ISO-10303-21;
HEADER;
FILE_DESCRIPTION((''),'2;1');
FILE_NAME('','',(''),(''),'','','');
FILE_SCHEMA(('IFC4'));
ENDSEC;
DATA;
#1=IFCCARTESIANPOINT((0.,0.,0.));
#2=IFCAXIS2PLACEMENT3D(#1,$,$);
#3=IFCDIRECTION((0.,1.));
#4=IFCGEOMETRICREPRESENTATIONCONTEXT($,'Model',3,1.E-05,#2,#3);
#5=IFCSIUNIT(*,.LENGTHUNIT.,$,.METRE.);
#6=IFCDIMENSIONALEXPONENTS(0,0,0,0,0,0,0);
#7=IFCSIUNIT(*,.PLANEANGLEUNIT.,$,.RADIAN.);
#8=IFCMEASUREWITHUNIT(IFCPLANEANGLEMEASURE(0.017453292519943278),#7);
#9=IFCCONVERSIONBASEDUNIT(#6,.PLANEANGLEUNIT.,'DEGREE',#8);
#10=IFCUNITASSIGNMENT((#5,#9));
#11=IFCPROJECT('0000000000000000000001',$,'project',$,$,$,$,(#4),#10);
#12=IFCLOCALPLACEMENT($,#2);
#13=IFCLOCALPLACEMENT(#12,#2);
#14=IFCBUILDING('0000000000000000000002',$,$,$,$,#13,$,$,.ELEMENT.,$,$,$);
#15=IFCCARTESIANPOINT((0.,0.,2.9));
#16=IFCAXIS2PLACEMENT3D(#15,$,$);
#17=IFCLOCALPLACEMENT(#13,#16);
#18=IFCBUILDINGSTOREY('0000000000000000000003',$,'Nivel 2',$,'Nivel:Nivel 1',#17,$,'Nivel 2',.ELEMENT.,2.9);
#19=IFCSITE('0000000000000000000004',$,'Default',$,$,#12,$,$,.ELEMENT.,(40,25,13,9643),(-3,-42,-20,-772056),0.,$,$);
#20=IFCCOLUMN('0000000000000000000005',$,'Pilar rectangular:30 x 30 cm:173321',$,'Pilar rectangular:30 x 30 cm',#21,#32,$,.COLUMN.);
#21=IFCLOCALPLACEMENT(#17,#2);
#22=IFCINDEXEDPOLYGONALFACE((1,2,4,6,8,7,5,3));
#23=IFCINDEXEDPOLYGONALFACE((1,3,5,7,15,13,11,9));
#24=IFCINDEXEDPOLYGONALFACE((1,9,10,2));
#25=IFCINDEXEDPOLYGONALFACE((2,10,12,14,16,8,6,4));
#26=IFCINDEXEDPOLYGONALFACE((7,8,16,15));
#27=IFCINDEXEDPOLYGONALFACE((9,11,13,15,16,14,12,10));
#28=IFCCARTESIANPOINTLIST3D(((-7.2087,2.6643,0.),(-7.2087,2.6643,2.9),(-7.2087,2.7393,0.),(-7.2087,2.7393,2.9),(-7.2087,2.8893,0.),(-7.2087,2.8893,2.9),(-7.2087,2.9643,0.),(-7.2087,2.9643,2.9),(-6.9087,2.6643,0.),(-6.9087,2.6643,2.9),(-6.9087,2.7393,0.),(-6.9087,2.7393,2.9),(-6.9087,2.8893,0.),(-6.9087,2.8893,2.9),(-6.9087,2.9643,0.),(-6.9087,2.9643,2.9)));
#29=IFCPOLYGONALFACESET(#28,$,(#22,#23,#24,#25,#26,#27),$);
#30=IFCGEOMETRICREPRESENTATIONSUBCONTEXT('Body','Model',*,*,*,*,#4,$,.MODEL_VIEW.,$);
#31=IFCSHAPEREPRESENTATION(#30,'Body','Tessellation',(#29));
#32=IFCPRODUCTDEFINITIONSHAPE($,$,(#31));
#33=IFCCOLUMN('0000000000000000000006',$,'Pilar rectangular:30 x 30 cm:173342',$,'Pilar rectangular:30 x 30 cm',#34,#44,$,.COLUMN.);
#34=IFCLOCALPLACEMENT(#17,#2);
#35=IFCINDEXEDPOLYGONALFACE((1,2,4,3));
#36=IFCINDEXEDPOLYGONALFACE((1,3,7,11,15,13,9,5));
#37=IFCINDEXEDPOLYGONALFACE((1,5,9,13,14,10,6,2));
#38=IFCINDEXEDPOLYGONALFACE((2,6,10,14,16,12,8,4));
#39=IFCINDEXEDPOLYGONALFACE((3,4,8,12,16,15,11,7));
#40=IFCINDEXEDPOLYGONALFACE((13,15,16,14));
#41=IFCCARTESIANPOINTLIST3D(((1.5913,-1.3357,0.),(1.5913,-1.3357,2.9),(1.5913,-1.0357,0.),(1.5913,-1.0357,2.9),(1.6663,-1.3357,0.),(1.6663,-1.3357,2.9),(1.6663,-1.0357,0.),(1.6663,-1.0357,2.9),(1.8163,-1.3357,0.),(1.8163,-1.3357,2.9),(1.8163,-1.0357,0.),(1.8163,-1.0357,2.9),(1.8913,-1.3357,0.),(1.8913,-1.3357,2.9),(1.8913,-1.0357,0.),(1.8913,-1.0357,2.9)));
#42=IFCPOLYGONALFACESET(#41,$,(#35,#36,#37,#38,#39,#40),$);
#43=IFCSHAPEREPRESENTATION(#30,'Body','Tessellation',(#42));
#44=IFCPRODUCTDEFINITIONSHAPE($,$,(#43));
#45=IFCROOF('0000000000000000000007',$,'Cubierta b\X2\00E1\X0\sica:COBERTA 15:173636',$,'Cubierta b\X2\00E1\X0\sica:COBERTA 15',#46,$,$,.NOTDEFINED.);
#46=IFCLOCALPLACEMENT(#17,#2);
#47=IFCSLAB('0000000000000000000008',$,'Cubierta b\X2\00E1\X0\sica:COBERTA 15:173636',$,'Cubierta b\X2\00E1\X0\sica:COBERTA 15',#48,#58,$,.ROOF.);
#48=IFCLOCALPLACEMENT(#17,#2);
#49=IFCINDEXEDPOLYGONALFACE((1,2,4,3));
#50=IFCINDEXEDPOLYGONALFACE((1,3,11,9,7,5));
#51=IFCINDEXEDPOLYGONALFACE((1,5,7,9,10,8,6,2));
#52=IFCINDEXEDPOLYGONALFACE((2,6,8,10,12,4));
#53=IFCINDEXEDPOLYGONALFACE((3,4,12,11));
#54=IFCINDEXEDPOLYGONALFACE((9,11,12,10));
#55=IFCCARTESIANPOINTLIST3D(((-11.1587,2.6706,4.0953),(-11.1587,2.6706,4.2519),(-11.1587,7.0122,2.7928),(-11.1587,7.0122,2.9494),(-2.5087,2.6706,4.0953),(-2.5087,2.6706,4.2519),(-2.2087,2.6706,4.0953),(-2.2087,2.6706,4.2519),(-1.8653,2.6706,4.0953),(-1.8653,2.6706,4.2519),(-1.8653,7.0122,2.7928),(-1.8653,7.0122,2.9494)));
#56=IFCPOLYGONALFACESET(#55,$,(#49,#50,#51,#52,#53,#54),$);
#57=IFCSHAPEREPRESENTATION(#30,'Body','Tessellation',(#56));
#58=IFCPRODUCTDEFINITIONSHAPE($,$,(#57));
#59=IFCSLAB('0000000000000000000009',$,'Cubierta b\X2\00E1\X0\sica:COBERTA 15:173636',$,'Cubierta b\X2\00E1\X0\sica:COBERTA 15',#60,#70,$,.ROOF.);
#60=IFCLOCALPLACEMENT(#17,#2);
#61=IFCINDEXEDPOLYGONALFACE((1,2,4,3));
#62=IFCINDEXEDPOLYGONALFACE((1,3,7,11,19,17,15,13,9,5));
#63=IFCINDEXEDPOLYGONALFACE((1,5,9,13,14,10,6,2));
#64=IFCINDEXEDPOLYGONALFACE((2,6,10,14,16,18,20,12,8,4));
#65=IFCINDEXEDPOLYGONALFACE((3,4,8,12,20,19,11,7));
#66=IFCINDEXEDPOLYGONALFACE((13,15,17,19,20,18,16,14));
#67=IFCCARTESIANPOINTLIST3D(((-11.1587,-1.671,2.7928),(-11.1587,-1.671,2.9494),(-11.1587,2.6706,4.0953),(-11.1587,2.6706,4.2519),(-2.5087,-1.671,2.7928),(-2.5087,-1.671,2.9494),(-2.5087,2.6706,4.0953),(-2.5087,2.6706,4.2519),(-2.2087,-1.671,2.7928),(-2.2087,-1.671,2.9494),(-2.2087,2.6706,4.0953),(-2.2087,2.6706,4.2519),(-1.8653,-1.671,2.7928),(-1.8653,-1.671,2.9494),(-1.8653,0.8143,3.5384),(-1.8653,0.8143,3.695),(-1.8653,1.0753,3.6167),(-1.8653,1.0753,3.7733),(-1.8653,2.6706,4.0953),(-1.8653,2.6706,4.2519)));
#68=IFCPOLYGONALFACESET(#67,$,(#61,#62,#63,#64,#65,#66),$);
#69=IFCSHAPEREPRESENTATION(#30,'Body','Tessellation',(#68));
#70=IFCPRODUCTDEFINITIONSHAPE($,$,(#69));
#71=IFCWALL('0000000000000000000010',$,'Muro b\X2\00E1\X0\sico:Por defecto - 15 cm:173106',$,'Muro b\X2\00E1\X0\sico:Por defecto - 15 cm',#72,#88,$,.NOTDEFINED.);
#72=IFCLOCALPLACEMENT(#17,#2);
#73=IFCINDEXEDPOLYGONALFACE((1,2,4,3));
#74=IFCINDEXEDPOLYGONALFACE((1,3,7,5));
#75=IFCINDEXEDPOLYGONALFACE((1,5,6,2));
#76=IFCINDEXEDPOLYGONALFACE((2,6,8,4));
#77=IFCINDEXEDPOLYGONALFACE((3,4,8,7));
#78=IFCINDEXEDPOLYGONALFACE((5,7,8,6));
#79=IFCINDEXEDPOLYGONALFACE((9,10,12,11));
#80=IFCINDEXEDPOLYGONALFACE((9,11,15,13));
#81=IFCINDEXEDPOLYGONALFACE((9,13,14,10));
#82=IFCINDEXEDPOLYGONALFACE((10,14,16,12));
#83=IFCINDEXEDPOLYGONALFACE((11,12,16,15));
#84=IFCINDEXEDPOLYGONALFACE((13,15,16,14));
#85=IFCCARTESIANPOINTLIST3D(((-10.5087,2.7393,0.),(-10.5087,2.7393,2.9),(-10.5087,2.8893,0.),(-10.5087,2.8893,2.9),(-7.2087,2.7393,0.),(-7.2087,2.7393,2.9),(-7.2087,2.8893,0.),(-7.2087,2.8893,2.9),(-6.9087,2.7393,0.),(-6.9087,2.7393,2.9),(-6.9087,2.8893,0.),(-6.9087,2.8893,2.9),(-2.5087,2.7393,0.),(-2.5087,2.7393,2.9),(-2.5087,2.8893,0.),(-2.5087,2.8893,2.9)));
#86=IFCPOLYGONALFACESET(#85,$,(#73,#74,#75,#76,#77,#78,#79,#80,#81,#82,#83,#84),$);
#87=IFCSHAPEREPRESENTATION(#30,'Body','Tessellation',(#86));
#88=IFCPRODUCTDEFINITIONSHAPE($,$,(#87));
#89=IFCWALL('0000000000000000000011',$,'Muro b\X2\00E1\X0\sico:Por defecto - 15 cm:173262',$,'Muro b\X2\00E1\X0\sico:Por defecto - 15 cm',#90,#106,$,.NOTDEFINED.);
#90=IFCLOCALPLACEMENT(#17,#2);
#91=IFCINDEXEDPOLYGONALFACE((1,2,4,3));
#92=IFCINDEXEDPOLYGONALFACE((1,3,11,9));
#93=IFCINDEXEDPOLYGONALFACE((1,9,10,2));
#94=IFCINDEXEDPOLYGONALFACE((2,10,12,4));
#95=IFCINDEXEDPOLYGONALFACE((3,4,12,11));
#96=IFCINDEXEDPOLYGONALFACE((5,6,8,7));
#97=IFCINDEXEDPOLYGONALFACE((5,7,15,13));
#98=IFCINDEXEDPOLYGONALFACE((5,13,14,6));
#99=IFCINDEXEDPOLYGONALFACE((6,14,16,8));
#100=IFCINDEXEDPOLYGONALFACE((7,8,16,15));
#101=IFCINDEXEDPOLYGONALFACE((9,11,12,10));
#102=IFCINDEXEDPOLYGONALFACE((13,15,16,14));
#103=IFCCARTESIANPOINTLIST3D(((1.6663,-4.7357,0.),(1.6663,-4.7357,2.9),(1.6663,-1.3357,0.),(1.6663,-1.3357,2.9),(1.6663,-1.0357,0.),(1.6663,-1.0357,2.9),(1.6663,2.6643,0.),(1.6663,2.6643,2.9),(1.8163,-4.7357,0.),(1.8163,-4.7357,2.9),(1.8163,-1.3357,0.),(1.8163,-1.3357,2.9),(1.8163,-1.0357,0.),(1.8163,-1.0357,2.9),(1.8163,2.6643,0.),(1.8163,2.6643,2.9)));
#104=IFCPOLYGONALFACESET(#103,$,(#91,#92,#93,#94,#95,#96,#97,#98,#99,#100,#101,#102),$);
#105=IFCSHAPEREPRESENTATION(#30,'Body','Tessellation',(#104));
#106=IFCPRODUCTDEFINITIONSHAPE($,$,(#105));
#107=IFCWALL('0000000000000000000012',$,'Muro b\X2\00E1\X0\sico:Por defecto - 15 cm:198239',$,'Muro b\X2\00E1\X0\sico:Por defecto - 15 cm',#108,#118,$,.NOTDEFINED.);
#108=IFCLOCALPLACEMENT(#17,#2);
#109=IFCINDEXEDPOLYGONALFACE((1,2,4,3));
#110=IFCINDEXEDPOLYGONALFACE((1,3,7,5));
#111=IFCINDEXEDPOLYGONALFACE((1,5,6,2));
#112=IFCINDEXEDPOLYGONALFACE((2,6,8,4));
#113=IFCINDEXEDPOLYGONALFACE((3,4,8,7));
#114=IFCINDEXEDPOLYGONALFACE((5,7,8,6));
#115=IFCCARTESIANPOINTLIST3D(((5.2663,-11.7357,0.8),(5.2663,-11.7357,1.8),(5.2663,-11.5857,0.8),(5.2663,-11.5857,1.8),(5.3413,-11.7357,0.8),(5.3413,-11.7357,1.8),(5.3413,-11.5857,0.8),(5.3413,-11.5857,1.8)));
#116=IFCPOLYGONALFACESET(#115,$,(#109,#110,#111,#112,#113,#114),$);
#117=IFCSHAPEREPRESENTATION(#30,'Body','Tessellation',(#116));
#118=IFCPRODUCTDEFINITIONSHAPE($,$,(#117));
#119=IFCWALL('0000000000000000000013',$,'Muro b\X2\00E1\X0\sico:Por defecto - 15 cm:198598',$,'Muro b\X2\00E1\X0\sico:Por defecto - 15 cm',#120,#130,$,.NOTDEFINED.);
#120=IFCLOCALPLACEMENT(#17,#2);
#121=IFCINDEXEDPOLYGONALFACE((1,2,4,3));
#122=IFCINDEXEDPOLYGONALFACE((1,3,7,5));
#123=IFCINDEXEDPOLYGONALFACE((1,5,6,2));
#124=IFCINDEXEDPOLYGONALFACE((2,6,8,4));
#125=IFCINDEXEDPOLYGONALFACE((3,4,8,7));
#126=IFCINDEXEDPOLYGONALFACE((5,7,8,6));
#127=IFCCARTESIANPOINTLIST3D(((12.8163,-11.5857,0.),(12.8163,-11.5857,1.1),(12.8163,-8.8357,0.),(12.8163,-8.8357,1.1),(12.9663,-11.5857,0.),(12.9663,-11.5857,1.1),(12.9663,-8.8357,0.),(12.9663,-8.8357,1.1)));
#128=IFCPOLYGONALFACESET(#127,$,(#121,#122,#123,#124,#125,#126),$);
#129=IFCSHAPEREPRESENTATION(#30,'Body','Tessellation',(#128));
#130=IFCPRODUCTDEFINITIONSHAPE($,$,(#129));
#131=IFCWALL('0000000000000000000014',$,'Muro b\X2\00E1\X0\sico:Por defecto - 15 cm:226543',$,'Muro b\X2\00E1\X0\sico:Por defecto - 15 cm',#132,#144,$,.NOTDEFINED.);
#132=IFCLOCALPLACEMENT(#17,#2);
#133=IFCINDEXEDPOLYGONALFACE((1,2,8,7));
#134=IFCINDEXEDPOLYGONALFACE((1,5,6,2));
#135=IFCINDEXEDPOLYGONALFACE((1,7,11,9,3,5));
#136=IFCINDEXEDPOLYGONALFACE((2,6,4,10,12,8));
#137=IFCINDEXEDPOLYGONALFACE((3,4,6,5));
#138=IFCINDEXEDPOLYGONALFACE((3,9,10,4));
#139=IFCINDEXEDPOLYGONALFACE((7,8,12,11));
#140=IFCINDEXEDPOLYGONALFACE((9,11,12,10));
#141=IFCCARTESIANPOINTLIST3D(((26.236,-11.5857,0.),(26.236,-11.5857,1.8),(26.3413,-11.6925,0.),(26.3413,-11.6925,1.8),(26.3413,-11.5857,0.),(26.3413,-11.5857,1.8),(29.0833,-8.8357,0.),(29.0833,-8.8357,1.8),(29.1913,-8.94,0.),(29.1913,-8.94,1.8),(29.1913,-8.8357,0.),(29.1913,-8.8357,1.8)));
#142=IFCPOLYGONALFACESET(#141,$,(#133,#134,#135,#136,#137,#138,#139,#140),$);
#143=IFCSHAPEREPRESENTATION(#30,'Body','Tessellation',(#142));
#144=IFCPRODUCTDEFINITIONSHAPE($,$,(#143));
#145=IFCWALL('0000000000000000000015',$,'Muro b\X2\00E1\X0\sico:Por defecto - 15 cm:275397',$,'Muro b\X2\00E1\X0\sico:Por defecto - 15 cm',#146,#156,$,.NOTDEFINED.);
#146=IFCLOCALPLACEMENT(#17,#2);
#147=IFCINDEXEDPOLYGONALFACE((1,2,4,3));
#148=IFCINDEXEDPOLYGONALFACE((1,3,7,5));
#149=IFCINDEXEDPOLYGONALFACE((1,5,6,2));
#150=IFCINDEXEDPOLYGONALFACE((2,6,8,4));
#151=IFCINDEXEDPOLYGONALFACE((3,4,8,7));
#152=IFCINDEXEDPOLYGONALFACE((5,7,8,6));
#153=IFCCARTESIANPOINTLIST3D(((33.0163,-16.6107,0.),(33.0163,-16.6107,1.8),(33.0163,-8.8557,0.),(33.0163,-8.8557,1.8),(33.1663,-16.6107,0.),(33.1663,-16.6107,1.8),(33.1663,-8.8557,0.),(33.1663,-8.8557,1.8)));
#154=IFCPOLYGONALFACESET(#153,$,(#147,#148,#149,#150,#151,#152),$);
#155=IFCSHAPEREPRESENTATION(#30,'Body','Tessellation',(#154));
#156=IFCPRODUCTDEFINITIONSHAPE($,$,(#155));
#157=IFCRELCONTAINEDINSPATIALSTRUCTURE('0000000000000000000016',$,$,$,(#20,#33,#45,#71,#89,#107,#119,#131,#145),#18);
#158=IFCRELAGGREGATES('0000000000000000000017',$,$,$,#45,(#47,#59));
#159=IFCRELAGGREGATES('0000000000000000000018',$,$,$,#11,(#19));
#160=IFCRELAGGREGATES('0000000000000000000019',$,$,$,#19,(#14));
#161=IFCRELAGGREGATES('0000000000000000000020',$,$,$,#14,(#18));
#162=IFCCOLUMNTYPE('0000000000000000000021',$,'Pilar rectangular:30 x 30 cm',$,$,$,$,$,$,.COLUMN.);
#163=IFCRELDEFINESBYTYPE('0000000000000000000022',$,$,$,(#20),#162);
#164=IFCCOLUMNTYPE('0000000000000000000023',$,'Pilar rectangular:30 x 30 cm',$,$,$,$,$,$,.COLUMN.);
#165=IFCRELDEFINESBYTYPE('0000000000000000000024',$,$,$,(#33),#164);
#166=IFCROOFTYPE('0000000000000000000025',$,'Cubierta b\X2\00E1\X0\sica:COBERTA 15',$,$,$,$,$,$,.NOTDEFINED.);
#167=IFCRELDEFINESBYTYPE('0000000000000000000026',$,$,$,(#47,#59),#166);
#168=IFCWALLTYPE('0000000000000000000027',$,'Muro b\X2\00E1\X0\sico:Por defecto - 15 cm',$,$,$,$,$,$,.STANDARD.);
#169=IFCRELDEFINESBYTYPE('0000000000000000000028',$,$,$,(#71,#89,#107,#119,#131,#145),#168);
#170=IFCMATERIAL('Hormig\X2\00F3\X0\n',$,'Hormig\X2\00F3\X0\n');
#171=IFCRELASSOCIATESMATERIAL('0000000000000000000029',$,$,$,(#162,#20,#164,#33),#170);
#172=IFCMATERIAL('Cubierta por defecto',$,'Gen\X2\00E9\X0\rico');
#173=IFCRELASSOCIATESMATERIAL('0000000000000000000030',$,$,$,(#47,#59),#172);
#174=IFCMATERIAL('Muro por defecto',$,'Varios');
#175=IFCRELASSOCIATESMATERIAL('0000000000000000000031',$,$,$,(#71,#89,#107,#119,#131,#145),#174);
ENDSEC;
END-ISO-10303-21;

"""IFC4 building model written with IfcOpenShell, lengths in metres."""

from ifc_helpers import new_model, entity, si_unit, converted_unit, direction, frame, origin, place, context, subcontext, project, spatial, indexed_curve, outline, extrude, source, transform, mapped, material, type_object, type_shapes, element, aggregate, save


model = new_model("IFC4")

# Units and contexts
model_context = context("Model", 3, precision=1e-05, world=origin(), true_north=direction((0.0, 1.0)))
body_context = subcontext(model_context, "Body", "Model", "MODEL_VIEW")
ifc_project = project(units=[si_unit("LENGTHUNIT", "METRE"), converted_unit("PLANEANGLEUNIT", "DEGREE", entity("IfcPlaneAngleMeasure", 0.017453292519943278), si_unit("PLANEANGLEUNIT", "RADIAN"), dimensions=[0, 0, 0, 0, 0, 0, 0])], contexts=[model_context])

# Site, building, storey
site_placement = place(None, origin())
site = spatial("IfcSite", under=ifc_project, at=site_placement, Name="Default", CompositionType="ELEMENT", RefLatitude=(40, 25, 13, 9643), RefLongitude=(-3, -42, -20, -772056), RefElevation=0.0)
building_placement = place(site_placement, origin())
building = spatial("IfcBuilding", under=site, at=building_placement, CompositionType="ELEMENT")
storey_placement = place(building_placement, frame((0.0, 0.0, 2.9)))
storey = spatial("IfcBuildingStorey", under=building, at=storey_placement, Name="Nivel 2", ObjectType="Nivel:Nivel 1", LongName="Nivel 2", CompositionType="ELEMENT", Elevation=2.9)

# Columns
ifc_material_1 = material(Name="Hormigón", Category="Hormigón")
column_type_1 = type_object("IfcColumnType", Name="Pilar rectangular:30 x 30 cm", PredefinedType="COLUMN", material=ifc_material_1)
shared_shape_1 = source(origin(), body_context, "Body", "SweptSolid", [
    extrude(outline(indexed_curve([(-0.15, -0.15), (0.15, -0.15), (0.15, -0.075), (0.15, 0.075), (0.15, 0.15), (-0.15, 0.15), (-0.15, 0.075), (-0.15, -0.075), (-0.15, -0.15)], self_intersect=False)), frame((-7.0587, 2.8143, 2.9), z_axis=(0.0, 0.0, 1.0), x_axis=(-1.0, 0.0, 0.0)), (0.0, 0.0, 1.0), 2.9),
])
type_shapes(column_type_1, [shared_shape_1])
column_1_placement = place(storey_placement, frame((0.0, 0.0, -2.9)))
element("IfcColumn", 1, at=column_1_placement, inside=storey, type_object=column_type_1, material=ifc_material_1, Name="Pilar rectangular:30 x 30 cm:173321", ObjectType="Pilar rectangular:30 x 30 cm", PredefinedType="COLUMN", context=body_context, shape_type="MappedRepresentation", body=[
    mapped(shared_shape_1, transform((0.0, 0.0, 0.0), scale=1.0)),
])
column_type_2 = type_object("IfcColumnType", Name="Pilar rectangular:30 x 30 cm", PredefinedType="COLUMN", material=ifc_material_1)
shared_shape_2 = source(origin(), body_context, "Body", "SweptSolid", [
    extrude(outline(indexed_curve([(-0.15, -0.15), (-0.075, -0.15), (0.075, -0.15), (0.15, -0.15), (0.15, 0.15), (0.075, 0.15), (-0.075, 0.15), (-0.15, 0.15), (-0.15, -0.15)], self_intersect=False)), frame((1.7413, -1.1857, 2.9), z_axis=(0.0, 0.0, 1.0), x_axis=(-1.0, 0.0, 0.0)), (0.0, 0.0, 1.0), 2.9),
])
type_shapes(column_type_2, [shared_shape_2])
column_2_placement = place(storey_placement, frame((0.0, 0.0, -2.9)))
element("IfcColumn", 2, at=column_2_placement, inside=storey, type_object=column_type_2, material=ifc_material_1, Name="Pilar rectangular:30 x 30 cm:173342", ObjectType="Pilar rectangular:30 x 30 cm", PredefinedType="COLUMN", context=body_context, shape_type="MappedRepresentation", body=[
    mapped(shared_shape_2, transform((0.0, 0.0, 0.0), scale=1.0)),
])

# Roof, slabs
roof_placement = place(storey_placement, frame((-11.1587, -1.671, 2.7928)))
roof = element("IfcRoof", 3, at=roof_placement, inside=storey, Name="Cubierta básica:COBERTA 15:173636", ObjectType="Cubierta básica:COBERTA 15", PredefinedType="NOTDEFINED")
ifc_material_2 = material(Name="Cubierta por defecto", Category="Genérico")
roof_type = type_object("IfcRoofType", Name="Cubierta básica:COBERTA 15", PredefinedType="NOTDEFINED")
slab_1_placement = place(roof_placement, origin())
slab_1 = element("IfcSlab", 4, at=slab_1_placement, type_object=roof_type, material=ifc_material_2, Name="Cubierta básica:COBERTA 15:173636", ObjectType="Cubierta básica:COBERTA 15", PredefinedType="ROOF", context=body_context, shape_type="SweptSolid", body=[
    extrude(outline(indexed_curve([(4.6467, 2.2664), (-4.6467, 2.2664), (-4.6467, -2.2664), (4.0033, -2.2664), (4.3033, -2.2664), (4.6467, -2.2664), (4.6467, 2.2664)], self_intersect=False)), frame((4.6467, 6.5123, 0.6512), z_axis=(0.0, 0.287348, 0.957826), x_axis=(1.0, 0.0, 0.0)), (0.0, -0.287348, 0.957826), 0.1566),
])
slab_2_placement = place(roof_placement, origin())
slab_2 = element("IfcSlab", 5, at=slab_2_placement, type_object=roof_type, material=ifc_material_2, Name="Cubierta básica:COBERTA 15:173636", ObjectType="Cubierta básica:COBERTA 15", PredefinedType="ROOF", context=body_context, shape_type="SweptSolid", body=[
    extrude(outline(indexed_curve([(4.6467, 2.2664), (4.3033, 2.2664), (4.0033, 2.2664), (-4.6467, 2.2664), (-4.6467, -2.2664), (4.0033, -2.2664), (4.3033, -2.2664), (4.6467, -2.2664), (4.6467, 0.3283), (4.6467, 0.6008), (4.6467, 2.2664)], self_intersect=False)), frame((4.6467, 2.1708, 0.6512), z_axis=(0.0, -0.287348, 0.957826), x_axis=(1.0, 0.0, 0.0)), (0.0, 0.287348, 0.957826), 0.1566),
])
aggregate(roof, [slab_1, slab_2])

# Walls, openings
ifc_material_3 = material(Name="Muro por defecto", Category="Varios")
wall_type_1 = type_object("IfcWallType", Name="Muro básico:Por defecto - 15 cm", PredefinedType="STANDARD")
wall_1_placement = place(storey_placement, frame((-10.5087, 2.8143, 0.0)))
wall_1 = element("IfcWall", 6, at=wall_1_placement, inside=storey, type_object=wall_type_1, material=ifc_material_3, Name="Muro básico:Por defecto - 15 cm:173106", ObjectType="Muro básico:Por defecto - 15 cm", PredefinedType="NOTDEFINED", context=body_context, shape_type="SweptSolid", body=[
    extrude(outline(indexed_curve([(8.0, 0.075), (0.0, 0.075), (0.0, -0.075), (8.0, -0.075), (8.0, 0.075)], self_intersect=False)), origin(), (0.0, 0.0, 1.0), 2.9),
])
opening_1_placement = place(storey_placement, frame((-10.5087, 2.8143, 0.0)))
element("IfcOpeningElement", 7, at=opening_1_placement, cuts=wall_1, PredefinedType="OPENING", context=body_context, shape_type="SweptSolid", body=[
    extrude(outline(indexed_curve([(-1.45, -0.075), (1.45, -0.075), (1.45, 0.075), (-1.45, 0.075), (-1.45, -0.075)], self_intersect=False)), frame((3.3, 0.0, 1.45), z_axis=(1.0, 0.0, 0.0), x_axis=(0.0, 0.0, -1.0)), (0.0, 0.0, 1.0), 0.3),
])
wall_2_placement = place(storey_placement, frame((1.7413, 2.6643, 0.0), z_axis=(0.0, 0.0, 1.0), x_axis=(0.0, -1.0, 0.0)))
wall_2 = element("IfcWall", 8, at=wall_2_placement, inside=storey, type_object=wall_type_1, material=ifc_material_3, Name="Muro básico:Por defecto - 15 cm:173262", ObjectType="Muro básico:Por defecto - 15 cm", PredefinedType="NOTDEFINED", context=body_context, shape_type="SweptSolid", body=[
    extrude(outline(indexed_curve([(7.4, 0.075), (0.0, 0.075), (0.0, -0.075), (7.4, -0.075), (7.4, 0.075)], self_intersect=False)), origin(), (0.0, 0.0, 1.0), 2.9),
])
opening_2_placement = place(storey_placement, frame((1.7413, 2.6643, 0.0), z_axis=(0.0, 0.0, 1.0), x_axis=(0.0, -1.0, 0.0)))
element("IfcOpeningElement", 9, at=opening_2_placement, cuts=wall_2, PredefinedType="OPENING", context=body_context, shape_type="SweptSolid", body=[
    extrude(outline(indexed_curve([(-1.45, -0.075), (1.45, -0.075), (1.45, 0.075), (-1.45, 0.075), (-1.45, -0.075)], self_intersect=False)), frame((4.0, 0.0, 1.45), z_axis=(-1.0, 0.0, 0.0), x_axis=(0.0, 0.0, 1.0)), (0.0, 0.0, 1.0), 0.3),
])

# Walls
wall_3_placement = place(storey_placement, frame((5.2663, -11.6607, 0.8)))
element("IfcWall", 10, at=wall_3_placement, inside=storey, type_object=wall_type_1, material=ifc_material_3, Name="Muro básico:Por defecto - 15 cm:198239", ObjectType="Muro básico:Por defecto - 15 cm", PredefinedType="NOTDEFINED", context=body_context, shape_type="SweptSolid", body=[
    extrude(outline(indexed_curve([(0.075, 0.075), (0.0, 0.075), (0.0, -0.075), (0.075, -0.075), (0.075, 0.075)], self_intersect=False)), origin(), (0.0, 0.0, 1.0), 1.0),
])
wall_4_placement = place(storey_placement, frame((12.8913, -8.8357, 0.0), z_axis=(0.0, 0.0, 1.0), x_axis=(0.0, -1.0, 0.0)))
element("IfcWall", 11, at=wall_4_placement, inside=storey, type_object=wall_type_1, material=ifc_material_3, Name="Muro básico:Por defecto - 15 cm:198598", ObjectType="Muro básico:Por defecto - 15 cm", PredefinedType="NOTDEFINED", context=body_context, shape_type="SweptSolid", body=[
    extrude(outline(indexed_curve([(2.75, 0.075), (0.0, 0.075), (0.0, -0.075), (2.75, -0.075), (2.75, 0.075)], self_intersect=False)), origin(), (0.0, 0.0, 1.0), 1.1),
])
wall_5_placement = place(storey_placement, frame((26.2881, -11.6397, 0.0), z_axis=(0.0, 0.0, 1.0), x_axis=(0.719296, 0.694704, 0.0)))
element("IfcWall", 12, at=wall_5_placement, inside=storey, type_object=wall_type_1, material=ifc_material_3, Name="Muro básico:Por defecto - 15 cm:226543", ObjectType="Muro básico:Por defecto - 15 cm", PredefinedType="NOTDEFINED", context=body_context, shape_type="SweptSolid", body=[
    extrude(outline(indexed_curve([(3.9637, -0.075), (4.0362, 0.0), (3.9585, 0.075), (0.0, 0.075), (0.0757, 0.0018), (0.0015, -0.075), (3.9637, -0.075)], self_intersect=False)), origin(), (0.0, 0.0, 1.0), 1.8),
])
wall_6_placement = place(storey_placement, frame((33.0913, -8.8557, 0.0), z_axis=(0.0, 0.0, 1.0), x_axis=(0.0, -1.0, 0.0)))
element("IfcWall", 13, at=wall_6_placement, inside=storey, type_object=wall_type_1, material=ifc_material_3, Name="Muro básico:Por defecto - 15 cm:275397", ObjectType="Muro básico:Por defecto - 15 cm", PredefinedType="NOTDEFINED", context=body_context, shape_type="SweptSolid", body=[
    extrude(outline(indexed_curve([(7.755, 0.075), (0.0, 0.075), (0.0, -0.075), (7.755, -0.075), (7.755, 0.075)], self_intersect=False)), origin(), (0.0, 0.0, 1.0), 1.8),
])

save(model, "model.ifc")
